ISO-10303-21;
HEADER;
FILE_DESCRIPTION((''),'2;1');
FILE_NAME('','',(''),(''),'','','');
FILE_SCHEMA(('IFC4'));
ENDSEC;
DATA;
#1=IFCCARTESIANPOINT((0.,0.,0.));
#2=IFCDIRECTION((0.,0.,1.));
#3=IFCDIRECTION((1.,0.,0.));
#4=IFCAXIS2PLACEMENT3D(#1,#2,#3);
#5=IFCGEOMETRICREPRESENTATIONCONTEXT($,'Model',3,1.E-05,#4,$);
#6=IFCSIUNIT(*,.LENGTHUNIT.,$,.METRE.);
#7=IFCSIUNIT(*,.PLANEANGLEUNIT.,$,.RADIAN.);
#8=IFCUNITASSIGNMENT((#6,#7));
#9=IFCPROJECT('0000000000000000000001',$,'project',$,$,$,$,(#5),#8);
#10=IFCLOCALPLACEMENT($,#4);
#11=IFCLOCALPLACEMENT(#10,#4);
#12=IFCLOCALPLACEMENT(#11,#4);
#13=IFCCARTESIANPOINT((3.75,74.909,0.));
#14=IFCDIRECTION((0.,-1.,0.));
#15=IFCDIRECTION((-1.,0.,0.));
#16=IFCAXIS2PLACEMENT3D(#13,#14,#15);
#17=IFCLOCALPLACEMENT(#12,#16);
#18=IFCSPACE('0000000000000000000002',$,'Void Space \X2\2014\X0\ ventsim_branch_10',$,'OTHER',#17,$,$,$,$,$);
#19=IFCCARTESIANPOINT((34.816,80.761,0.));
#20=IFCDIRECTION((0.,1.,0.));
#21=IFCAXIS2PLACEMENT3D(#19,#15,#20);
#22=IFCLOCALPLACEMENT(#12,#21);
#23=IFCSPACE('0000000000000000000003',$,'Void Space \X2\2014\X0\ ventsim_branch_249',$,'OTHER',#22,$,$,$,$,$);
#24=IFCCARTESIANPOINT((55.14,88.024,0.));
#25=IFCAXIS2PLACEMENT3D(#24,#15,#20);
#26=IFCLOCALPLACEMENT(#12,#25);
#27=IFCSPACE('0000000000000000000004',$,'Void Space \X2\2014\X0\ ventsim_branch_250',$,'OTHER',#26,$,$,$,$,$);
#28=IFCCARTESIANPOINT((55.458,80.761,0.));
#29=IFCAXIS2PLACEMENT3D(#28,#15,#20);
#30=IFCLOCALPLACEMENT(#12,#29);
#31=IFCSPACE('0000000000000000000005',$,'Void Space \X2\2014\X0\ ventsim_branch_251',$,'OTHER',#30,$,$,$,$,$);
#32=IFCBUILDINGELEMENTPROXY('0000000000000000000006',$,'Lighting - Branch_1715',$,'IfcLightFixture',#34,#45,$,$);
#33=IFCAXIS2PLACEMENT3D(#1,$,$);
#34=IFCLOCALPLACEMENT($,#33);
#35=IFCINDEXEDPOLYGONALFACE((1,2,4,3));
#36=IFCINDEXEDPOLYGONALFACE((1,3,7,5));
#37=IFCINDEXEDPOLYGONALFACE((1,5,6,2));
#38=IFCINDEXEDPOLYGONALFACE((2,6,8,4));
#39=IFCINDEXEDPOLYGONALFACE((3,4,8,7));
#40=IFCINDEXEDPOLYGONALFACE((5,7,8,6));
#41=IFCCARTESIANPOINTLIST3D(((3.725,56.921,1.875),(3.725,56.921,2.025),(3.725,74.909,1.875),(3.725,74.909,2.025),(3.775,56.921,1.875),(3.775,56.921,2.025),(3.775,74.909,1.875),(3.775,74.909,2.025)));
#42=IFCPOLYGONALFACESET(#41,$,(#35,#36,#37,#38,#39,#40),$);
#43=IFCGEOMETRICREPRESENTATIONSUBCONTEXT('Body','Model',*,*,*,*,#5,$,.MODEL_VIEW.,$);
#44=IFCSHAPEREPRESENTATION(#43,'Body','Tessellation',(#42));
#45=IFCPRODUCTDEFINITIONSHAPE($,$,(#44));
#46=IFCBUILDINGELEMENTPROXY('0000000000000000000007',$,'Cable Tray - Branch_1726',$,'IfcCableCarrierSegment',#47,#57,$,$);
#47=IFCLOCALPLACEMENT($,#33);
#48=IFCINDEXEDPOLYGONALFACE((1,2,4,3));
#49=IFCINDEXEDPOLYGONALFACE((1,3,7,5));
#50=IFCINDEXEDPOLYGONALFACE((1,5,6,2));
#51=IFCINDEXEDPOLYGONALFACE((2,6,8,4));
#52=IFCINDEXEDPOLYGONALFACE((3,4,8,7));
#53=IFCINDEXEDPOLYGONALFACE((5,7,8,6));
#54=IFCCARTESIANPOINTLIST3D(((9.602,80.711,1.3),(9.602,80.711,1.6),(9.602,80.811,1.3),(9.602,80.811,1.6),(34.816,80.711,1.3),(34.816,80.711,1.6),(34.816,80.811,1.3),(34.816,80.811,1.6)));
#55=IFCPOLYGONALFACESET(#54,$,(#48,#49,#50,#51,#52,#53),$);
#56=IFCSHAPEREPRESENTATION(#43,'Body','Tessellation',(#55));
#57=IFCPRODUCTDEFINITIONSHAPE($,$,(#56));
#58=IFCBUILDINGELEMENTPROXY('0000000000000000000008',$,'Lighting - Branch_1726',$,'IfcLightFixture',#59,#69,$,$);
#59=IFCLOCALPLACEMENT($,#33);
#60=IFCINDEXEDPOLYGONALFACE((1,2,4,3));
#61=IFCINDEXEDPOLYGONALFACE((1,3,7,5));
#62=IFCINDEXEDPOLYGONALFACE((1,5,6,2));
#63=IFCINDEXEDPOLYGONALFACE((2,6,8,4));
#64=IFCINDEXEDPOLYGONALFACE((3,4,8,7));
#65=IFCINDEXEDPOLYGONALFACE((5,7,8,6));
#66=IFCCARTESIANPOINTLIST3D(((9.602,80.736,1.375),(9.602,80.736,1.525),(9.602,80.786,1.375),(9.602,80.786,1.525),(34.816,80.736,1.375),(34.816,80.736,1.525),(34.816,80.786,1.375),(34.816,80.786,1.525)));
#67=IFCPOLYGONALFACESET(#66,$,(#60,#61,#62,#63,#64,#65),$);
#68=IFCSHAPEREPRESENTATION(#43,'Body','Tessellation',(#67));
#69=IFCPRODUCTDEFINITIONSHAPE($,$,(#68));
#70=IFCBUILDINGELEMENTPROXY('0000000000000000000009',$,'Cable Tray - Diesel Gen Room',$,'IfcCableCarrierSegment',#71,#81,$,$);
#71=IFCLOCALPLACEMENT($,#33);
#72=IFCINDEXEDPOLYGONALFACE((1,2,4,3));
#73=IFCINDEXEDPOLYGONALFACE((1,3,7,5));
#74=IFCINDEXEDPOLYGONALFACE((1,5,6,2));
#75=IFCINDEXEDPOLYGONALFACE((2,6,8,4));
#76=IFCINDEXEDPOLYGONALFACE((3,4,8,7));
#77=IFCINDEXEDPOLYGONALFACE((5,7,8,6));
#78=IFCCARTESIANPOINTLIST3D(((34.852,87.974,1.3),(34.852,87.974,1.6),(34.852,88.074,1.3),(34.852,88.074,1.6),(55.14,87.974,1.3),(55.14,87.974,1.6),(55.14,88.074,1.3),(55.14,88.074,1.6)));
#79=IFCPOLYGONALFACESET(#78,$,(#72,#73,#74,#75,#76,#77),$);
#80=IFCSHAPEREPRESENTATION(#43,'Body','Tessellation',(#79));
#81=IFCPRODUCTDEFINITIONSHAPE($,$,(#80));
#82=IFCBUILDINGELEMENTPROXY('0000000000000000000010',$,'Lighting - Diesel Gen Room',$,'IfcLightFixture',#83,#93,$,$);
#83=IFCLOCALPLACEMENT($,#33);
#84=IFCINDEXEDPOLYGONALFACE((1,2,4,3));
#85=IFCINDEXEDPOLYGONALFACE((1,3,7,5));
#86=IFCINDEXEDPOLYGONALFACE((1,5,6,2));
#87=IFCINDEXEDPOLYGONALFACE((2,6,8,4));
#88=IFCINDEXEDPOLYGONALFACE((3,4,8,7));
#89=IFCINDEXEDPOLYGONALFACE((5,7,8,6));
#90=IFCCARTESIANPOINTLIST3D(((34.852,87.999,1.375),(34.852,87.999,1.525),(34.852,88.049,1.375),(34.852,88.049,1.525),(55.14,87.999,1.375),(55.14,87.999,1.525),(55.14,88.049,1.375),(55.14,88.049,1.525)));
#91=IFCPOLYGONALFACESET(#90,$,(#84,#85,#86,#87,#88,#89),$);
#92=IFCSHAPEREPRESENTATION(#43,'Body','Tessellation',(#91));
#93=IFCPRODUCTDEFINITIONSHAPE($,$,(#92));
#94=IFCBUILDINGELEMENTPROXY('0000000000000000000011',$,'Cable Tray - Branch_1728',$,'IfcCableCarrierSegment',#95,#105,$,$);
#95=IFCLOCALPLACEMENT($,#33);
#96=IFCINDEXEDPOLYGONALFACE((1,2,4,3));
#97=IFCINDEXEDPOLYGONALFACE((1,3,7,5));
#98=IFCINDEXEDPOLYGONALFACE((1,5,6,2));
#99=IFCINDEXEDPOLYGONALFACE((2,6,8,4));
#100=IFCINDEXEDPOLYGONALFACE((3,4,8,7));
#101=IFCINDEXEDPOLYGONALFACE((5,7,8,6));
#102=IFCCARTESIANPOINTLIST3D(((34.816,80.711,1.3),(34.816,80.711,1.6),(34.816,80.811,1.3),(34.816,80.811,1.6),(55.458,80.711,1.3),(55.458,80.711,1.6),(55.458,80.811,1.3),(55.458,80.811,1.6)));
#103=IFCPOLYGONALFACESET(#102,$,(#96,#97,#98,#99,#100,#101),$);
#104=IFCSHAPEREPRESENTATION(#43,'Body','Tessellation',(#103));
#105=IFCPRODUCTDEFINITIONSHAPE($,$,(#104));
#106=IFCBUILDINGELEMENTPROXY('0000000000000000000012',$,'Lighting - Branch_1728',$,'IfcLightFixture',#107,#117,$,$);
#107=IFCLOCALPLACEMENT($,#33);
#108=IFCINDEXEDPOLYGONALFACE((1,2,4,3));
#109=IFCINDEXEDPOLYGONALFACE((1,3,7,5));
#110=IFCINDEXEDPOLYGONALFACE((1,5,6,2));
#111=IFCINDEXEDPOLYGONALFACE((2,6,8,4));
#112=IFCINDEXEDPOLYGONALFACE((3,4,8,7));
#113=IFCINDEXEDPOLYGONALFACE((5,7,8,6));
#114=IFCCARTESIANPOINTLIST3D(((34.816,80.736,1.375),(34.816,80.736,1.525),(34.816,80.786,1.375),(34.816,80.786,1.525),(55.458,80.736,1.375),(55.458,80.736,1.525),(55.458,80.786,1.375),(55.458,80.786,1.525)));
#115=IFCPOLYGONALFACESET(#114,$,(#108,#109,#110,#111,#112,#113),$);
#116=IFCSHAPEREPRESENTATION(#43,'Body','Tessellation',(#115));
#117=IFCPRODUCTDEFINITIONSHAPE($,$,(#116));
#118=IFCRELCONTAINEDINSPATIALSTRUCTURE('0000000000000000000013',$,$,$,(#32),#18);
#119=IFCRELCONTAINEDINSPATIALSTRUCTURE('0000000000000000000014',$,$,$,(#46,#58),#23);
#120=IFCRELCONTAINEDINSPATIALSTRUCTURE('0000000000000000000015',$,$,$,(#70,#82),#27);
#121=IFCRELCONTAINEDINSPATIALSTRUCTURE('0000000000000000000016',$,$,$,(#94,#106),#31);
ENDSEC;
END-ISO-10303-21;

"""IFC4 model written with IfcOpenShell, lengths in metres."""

from ifc_helpers import new_model, si_unit, frame, origin_with_axes, origin_2d_with_axis, place, context, subcontext, project, spatial, rectangle, extrude, element, save


model = new_model("IFC4")

# Units and contexts
model_context = context("Model", 3, precision=1e-05, world=origin_with_axes())
body_context = subcontext(model_context, "Body", "Model", "MODEL_VIEW")
ifc_project = project(units=[si_unit("LENGTHUNIT", "METRE"), si_unit("PLANEANGLEUNIT", "RADIAN")], contexts=[model_context])

# Shared definitions
placement_1 = place(None, origin_with_axes())
placement_2 = place(placement_1, origin_with_axes())
placement_3 = place(placement_2, origin_with_axes())

# Shared definitions
space_1_placement = place(placement_3, frame((3.75, 74.909, 0.0), z_axis=(0.0, -1.0, 0.0), x_axis=(-1.0, 0.0, 0.0)))
space_1 = spatial("IfcSpace", at=space_1_placement, Name="Void Space — ventsim_branch_10", ObjectType="OTHER")

# Building element proxy
proxy_1_placement = place(placement_3, frame((3.75, 74.909, 1.95), z_axis=(0.0, -1.0, 0.0), x_axis=(0.0, 0.0, 1.0)))
element("IfcBuildingElementProxy", 1, at=proxy_1_placement, inside=space_1, Name="Lighting - Branch_1715", ObjectType="IfcLightFixture", context=body_context, shape_type="SweptSolid", body=[
    extrude(rectangle(XDim=0.15, YDim=0.05, at=origin_2d_with_axis()), origin_with_axes(), (0.0, 0.0, 1.0), 17.988),
])

# Shared definitions
space_2_placement = place(placement_3, frame((34.816, 80.761, 0.0), z_axis=(-1.0, 0.0, 0.0), x_axis=(0.0, 1.0, 0.0)))
space_2 = spatial("IfcSpace", at=space_2_placement, Name="Void Space — ventsim_branch_249", ObjectType="OTHER")

# Building element proxies
proxy_2_placement = place(placement_3, frame((34.816, 80.761, 1.45), z_axis=(-1.0, 0.0, 0.0), x_axis=(0.0, 0.0, 1.0)))
element("IfcBuildingElementProxy", 2, at=proxy_2_placement, inside=space_2, Name="Cable Tray - Branch_1726", ObjectType="IfcCableCarrierSegment", context=body_context, shape_type="SweptSolid", body=[
    extrude(rectangle(XDim=0.3, YDim=0.1, at=origin_2d_with_axis()), origin_with_axes(), (0.0, 0.0, 1.0), 25.214),
])
proxy_3_placement = place(placement_3, frame((34.816, 80.761, 1.45), z_axis=(-1.0, 0.0, 0.0), x_axis=(0.0, 0.0, 1.0)))
element("IfcBuildingElementProxy", 3, at=proxy_3_placement, inside=space_2, Name="Lighting - Branch_1726", ObjectType="IfcLightFixture", context=body_context, shape_type="SweptSolid", body=[
    extrude(rectangle(XDim=0.15, YDim=0.05, at=origin_2d_with_axis()), origin_with_axes(), (0.0, 0.0, 1.0), 25.214),
])

# Shared definitions
space_3_placement = place(placement_3, frame((55.14, 88.024, 0.0), z_axis=(-1.0, 0.0, 0.0), x_axis=(0.0, 1.0, 0.0)))
space_3 = spatial("IfcSpace", at=space_3_placement, Name="Void Space — ventsim_branch_250", ObjectType="OTHER")

# Building element proxies
proxy_4_placement = place(placement_3, frame((55.14, 88.024, 1.45), z_axis=(-1.0, 0.0, 0.0), x_axis=(0.0, 0.0, 1.0)))
element("IfcBuildingElementProxy", 4, at=proxy_4_placement, inside=space_3, Name="Cable Tray - Diesel Gen Room", ObjectType="IfcCableCarrierSegment", context=body_context, shape_type="SweptSolid", body=[
    extrude(rectangle(XDim=0.3, YDim=0.1, at=origin_2d_with_axis()), origin_with_axes(), (0.0, 0.0, 1.0), 20.288),
])
proxy_5_placement = place(placement_3, frame((55.14, 88.024, 1.45), z_axis=(-1.0, 0.0, 0.0), x_axis=(0.0, 0.0, 1.0)))
element("IfcBuildingElementProxy", 5, at=proxy_5_placement, inside=space_3, Name="Lighting - Diesel Gen Room", ObjectType="IfcLightFixture", context=body_context, shape_type="SweptSolid", body=[
    extrude(rectangle(XDim=0.15, YDim=0.05, at=origin_2d_with_axis()), origin_with_axes(), (0.0, 0.0, 1.0), 20.288),
])

# Shared definitions
space_4_placement = place(placement_3, frame((55.458, 80.761, 0.0), z_axis=(-1.0, 0.0, 0.0), x_axis=(0.0, 1.0, 0.0)))
space_4 = spatial("IfcSpace", at=space_4_placement, Name="Void Space — ventsim_branch_251", ObjectType="OTHER")

# Building element proxies
proxy_6_placement = place(placement_3, frame((55.458, 80.761, 1.45), z_axis=(-1.0, 0.0, 0.0), x_axis=(0.0, 0.0, 1.0)))
element("IfcBuildingElementProxy", 6, at=proxy_6_placement, inside=space_4, Name="Cable Tray - Branch_1728", ObjectType="IfcCableCarrierSegment", context=body_context, shape_type="SweptSolid", body=[
    extrude(rectangle(XDim=0.3, YDim=0.1, at=origin_2d_with_axis()), origin_with_axes(), (0.0, 0.0, 1.0), 20.642),
])
proxy_7_placement = place(placement_3, frame((55.458, 80.761, 1.45), z_axis=(-1.0, 0.0, 0.0), x_axis=(0.0, 0.0, 1.0)))
element("IfcBuildingElementProxy", 7, at=proxy_7_placement, inside=space_4, Name="Lighting - Branch_1728", ObjectType="IfcLightFixture", context=body_context, shape_type="SweptSolid", body=[
    extrude(rectangle(XDim=0.15, YDim=0.05, at=origin_2d_with_axis()), origin_with_axes(), (0.0, 0.0, 1.0), 20.642),
])

save(model, "model.ifc")
